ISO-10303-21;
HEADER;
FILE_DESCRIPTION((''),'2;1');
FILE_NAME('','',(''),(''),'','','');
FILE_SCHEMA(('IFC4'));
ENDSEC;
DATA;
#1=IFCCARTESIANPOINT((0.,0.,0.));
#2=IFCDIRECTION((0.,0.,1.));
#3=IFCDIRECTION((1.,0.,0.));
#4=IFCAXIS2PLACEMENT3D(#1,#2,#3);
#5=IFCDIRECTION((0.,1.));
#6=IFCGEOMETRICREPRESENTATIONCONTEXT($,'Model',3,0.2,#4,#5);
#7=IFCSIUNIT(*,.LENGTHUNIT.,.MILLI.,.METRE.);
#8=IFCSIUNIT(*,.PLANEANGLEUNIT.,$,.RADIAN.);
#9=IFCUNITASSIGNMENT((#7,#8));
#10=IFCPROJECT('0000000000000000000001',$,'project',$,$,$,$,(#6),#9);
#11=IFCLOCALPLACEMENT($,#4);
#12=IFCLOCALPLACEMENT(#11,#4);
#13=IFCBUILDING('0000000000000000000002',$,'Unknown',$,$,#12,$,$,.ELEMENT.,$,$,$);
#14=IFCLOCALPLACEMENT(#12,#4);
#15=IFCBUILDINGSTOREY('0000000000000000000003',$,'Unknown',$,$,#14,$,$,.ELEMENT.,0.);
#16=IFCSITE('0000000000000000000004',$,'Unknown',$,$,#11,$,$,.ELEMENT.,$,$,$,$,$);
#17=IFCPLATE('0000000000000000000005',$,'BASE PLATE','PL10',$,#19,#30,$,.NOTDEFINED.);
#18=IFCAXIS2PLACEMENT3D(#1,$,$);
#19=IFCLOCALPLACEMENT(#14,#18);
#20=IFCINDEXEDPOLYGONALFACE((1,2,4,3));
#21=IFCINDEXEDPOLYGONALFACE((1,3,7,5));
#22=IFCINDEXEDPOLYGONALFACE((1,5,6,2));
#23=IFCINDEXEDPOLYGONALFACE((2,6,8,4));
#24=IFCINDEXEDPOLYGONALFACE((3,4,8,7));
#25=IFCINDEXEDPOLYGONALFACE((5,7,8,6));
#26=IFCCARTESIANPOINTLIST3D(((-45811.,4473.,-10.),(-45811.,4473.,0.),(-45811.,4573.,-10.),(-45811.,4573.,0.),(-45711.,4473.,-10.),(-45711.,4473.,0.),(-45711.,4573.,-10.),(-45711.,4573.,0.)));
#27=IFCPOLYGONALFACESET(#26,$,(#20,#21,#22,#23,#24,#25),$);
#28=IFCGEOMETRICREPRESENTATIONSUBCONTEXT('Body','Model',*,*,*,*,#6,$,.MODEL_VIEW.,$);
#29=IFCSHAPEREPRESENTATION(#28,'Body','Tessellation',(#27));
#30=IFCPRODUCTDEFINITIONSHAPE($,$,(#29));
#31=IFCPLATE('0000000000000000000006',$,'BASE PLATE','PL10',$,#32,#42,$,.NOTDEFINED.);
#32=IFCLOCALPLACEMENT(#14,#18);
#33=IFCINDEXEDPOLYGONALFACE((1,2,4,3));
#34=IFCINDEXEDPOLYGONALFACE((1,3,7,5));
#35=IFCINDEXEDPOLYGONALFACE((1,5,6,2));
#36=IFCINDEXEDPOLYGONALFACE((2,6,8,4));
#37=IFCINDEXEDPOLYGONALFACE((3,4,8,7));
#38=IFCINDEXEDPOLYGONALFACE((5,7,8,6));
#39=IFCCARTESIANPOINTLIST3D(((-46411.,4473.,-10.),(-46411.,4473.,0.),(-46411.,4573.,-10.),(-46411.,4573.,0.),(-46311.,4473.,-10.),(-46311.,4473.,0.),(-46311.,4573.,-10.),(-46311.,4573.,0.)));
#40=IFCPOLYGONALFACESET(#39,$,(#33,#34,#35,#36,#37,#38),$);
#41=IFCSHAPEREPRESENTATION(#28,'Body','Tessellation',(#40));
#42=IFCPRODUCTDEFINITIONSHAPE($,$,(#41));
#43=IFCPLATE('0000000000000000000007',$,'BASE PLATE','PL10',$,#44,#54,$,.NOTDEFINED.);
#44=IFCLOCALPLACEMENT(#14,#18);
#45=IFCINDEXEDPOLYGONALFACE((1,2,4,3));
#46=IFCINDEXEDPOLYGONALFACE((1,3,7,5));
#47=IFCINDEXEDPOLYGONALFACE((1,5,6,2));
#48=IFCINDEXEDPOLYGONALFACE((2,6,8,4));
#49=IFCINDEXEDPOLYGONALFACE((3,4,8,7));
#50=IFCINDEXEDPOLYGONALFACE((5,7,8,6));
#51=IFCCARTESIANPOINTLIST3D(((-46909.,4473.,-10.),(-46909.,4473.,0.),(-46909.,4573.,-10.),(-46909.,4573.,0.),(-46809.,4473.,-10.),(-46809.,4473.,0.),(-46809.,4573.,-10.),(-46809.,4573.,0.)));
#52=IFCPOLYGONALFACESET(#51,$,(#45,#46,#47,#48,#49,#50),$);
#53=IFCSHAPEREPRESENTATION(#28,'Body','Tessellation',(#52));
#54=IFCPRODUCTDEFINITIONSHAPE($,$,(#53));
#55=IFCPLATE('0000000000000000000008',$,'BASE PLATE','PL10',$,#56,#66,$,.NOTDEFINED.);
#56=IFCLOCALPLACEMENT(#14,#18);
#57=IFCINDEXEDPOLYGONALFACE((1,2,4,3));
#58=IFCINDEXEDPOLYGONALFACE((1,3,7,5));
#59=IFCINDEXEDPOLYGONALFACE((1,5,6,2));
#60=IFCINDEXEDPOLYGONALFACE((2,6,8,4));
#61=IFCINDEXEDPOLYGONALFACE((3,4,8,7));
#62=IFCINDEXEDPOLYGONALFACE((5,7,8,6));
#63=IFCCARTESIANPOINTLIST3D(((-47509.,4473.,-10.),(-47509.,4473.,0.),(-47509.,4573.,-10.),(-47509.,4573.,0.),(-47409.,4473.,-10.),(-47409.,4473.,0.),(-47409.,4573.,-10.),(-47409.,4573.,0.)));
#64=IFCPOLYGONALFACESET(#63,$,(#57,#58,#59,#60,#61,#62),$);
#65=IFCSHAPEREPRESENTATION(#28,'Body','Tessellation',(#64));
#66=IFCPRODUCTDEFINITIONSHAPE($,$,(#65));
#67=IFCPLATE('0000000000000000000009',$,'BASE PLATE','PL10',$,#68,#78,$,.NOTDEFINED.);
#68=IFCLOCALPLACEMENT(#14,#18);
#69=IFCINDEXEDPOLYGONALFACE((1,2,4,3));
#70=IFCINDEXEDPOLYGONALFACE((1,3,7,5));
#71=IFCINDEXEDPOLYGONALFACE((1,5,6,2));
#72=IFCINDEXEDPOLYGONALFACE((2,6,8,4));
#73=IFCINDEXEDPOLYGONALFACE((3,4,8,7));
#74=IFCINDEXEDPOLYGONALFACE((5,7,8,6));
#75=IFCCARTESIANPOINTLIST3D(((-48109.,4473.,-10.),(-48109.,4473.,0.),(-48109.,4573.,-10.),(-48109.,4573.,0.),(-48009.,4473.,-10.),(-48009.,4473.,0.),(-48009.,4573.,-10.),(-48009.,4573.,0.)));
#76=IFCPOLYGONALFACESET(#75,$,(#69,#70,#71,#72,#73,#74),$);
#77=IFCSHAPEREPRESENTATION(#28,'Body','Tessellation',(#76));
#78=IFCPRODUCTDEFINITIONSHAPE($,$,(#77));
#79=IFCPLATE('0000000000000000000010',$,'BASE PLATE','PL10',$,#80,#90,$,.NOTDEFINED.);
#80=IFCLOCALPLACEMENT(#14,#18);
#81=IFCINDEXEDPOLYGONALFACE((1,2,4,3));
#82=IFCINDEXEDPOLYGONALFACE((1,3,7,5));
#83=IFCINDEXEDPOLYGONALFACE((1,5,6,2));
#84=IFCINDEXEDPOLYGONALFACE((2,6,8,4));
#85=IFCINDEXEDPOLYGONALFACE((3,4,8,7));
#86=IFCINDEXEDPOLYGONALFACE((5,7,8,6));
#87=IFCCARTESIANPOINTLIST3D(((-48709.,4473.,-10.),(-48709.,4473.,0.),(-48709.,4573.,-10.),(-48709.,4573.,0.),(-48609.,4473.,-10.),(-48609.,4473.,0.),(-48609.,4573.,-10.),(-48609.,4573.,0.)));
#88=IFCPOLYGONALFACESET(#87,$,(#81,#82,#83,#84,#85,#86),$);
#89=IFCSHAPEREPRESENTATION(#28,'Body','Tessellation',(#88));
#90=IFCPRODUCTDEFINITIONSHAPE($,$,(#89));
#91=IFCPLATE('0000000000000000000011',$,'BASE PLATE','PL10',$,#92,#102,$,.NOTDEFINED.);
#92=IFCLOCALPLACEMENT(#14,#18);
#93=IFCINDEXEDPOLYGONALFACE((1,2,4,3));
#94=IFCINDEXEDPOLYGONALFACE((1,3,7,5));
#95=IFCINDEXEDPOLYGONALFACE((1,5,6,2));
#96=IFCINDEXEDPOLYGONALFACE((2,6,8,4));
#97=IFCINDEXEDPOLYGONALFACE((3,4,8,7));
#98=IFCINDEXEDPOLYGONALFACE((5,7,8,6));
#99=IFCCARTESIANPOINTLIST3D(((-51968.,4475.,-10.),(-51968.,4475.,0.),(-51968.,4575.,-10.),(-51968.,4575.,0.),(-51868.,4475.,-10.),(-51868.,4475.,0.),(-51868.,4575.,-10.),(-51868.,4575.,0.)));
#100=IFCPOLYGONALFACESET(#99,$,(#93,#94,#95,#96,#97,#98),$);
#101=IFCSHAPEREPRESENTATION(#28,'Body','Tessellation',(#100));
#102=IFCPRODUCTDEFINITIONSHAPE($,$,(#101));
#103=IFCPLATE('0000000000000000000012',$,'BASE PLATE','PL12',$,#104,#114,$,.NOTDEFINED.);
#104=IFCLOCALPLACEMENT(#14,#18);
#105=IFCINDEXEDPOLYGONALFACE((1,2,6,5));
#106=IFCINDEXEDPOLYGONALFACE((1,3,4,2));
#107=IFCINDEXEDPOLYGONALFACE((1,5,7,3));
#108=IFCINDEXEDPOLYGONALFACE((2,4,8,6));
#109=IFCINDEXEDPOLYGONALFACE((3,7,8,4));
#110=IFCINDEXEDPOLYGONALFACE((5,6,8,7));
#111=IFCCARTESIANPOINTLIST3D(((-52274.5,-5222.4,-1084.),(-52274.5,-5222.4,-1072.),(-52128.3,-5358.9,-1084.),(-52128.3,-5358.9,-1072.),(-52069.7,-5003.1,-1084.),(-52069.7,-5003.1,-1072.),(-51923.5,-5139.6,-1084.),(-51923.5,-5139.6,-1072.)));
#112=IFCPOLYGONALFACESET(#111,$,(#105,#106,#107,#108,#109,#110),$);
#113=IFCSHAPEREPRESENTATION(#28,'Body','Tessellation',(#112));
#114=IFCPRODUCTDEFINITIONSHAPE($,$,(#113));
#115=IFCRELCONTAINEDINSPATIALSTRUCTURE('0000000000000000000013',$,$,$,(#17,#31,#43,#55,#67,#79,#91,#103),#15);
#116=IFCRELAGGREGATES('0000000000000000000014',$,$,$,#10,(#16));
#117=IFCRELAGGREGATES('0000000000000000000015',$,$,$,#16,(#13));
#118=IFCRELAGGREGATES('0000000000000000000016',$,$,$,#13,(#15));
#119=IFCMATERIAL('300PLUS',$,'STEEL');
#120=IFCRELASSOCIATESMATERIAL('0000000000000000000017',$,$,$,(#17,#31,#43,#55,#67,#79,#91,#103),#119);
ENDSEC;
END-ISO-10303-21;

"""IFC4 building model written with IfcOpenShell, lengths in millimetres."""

from ifc_helpers import new_model, si_unit, direction, frame, origin_with_axes, place, context, subcontext, project, spatial, line, indexed_curve, outline, extrude, material, element, save


model = new_model("IFC4")

# Units and contexts
model_context = context("Model", 3, precision=0.2, world=origin_with_axes(), true_north=direction((0.0, 1.0)))
body_context = subcontext(model_context, "Body", "Model", "MODEL_VIEW")
ifc_project = project(units=[si_unit("LENGTHUNIT", "METRE", prefix="MILLI"), si_unit("PLANEANGLEUNIT", "RADIAN")], contexts=[model_context])

# Site, building, storey
site_placement = place(None, origin_with_axes())
site = spatial("IfcSite", under=ifc_project, at=site_placement, Name="Unknown", CompositionType="ELEMENT")
building_placement = place(site_placement, origin_with_axes())
building = spatial("IfcBuilding", under=site, at=building_placement, Name="Unknown", CompositionType="ELEMENT")
storey_placement = place(building_placement, origin_with_axes())
storey = spatial("IfcBuildingStorey", under=building, at=storey_placement, Name="Unknown", CompositionType="ELEMENT", Elevation=0.0)

# Shared definitions
ifc_material_1 = material(Name="300PLUS", Category="STEEL")

# Plates
for number, where, z_axis, x_axis, name in (
    (1, (-45811.0, 4473.0, -5.0), (0.0, 0.0, 1.0), (1.0, 0.0, 0.0), "BASE PLATE"),
    (2, (-46411.0, 4473.0, -5.0), (0.0, 0.0, 1.0), (1.0, 0.0, 0.0), "BASE PLATE"),
    (3, (-46909.0, 4473.0, -5.0), (0.0, 0.0, 1.0), (1.0, 0.0, 0.0), "BASE PLATE"),
    (4, (-47509.0, 4473.0, -5.0), (0.0, 0.0, 1.0), (1.0, 0.0, 0.0), "BASE PLATE"),
    (5, (-48109.0, 4473.0, -5.0), (0.0, 0.0, 1.0), (1.0, 0.0, 0.0), "BASE PLATE"),
    (6, (-48709.0, 4473.0, -5.0), (0.0, 0.0, 1.0), (1.0, 0.0, 0.0), "BASE PLATE"),
    (7, (-51968.0, 4475.0, -5.0), (0.0, 0.0, 1.0), (1.0, 0.0, 0.0), "BASE PLATE"),
):
    element("IfcPlate", number, at=place(storey_placement, frame(where, z_axis=z_axis, x_axis=x_axis)), inside=storey, material=ifc_material_1, Name=name, Description="PL10", PredefinedType="NOTDEFINED", context=body_context, shape_type="SolidModel", body=[
        extrude(outline(indexed_curve([(0.0, 0.0), (100.0, 0.0), (100.0, 100.0), (0.0, 100.0)], segments=[line(1, 2, 3, 4, 1)])), frame((0.0, 0.0, 5.0), z_axis=(0.0, 0.0, 1.0), x_axis=(1.0, 0.0, 0.0)), (0.0, 0.0, -1.0), 10.0),
    ])
plate_placement = place(storey_placement, frame((-52128.3, -5358.9, -1078.0), z_axis=(0.0, 0.0, 1.0), x_axis=(0.682532, 0.730856, 0.0)))
element("IfcPlate", 8, at=plate_placement, inside=storey, material=ifc_material_1, Name="BASE PLATE", Description="PL12", PredefinedType="NOTDEFINED", context=body_context, shape_type="SolidModel", body=[
    extrude(outline(indexed_curve([(0.0, 0.0), (300.1, 0.0), (300.0, 200.0), (0.0, 200.0)], segments=[line(1, 2, 3, 4, 1)])), frame((0.0, 0.0, 6.0), z_axis=(0.0, 0.0, 1.0), x_axis=(1.0, 0.0, 0.0)), (0.0, 0.0, -1.0), 12.0),
])

save(model, "model.ifc")
